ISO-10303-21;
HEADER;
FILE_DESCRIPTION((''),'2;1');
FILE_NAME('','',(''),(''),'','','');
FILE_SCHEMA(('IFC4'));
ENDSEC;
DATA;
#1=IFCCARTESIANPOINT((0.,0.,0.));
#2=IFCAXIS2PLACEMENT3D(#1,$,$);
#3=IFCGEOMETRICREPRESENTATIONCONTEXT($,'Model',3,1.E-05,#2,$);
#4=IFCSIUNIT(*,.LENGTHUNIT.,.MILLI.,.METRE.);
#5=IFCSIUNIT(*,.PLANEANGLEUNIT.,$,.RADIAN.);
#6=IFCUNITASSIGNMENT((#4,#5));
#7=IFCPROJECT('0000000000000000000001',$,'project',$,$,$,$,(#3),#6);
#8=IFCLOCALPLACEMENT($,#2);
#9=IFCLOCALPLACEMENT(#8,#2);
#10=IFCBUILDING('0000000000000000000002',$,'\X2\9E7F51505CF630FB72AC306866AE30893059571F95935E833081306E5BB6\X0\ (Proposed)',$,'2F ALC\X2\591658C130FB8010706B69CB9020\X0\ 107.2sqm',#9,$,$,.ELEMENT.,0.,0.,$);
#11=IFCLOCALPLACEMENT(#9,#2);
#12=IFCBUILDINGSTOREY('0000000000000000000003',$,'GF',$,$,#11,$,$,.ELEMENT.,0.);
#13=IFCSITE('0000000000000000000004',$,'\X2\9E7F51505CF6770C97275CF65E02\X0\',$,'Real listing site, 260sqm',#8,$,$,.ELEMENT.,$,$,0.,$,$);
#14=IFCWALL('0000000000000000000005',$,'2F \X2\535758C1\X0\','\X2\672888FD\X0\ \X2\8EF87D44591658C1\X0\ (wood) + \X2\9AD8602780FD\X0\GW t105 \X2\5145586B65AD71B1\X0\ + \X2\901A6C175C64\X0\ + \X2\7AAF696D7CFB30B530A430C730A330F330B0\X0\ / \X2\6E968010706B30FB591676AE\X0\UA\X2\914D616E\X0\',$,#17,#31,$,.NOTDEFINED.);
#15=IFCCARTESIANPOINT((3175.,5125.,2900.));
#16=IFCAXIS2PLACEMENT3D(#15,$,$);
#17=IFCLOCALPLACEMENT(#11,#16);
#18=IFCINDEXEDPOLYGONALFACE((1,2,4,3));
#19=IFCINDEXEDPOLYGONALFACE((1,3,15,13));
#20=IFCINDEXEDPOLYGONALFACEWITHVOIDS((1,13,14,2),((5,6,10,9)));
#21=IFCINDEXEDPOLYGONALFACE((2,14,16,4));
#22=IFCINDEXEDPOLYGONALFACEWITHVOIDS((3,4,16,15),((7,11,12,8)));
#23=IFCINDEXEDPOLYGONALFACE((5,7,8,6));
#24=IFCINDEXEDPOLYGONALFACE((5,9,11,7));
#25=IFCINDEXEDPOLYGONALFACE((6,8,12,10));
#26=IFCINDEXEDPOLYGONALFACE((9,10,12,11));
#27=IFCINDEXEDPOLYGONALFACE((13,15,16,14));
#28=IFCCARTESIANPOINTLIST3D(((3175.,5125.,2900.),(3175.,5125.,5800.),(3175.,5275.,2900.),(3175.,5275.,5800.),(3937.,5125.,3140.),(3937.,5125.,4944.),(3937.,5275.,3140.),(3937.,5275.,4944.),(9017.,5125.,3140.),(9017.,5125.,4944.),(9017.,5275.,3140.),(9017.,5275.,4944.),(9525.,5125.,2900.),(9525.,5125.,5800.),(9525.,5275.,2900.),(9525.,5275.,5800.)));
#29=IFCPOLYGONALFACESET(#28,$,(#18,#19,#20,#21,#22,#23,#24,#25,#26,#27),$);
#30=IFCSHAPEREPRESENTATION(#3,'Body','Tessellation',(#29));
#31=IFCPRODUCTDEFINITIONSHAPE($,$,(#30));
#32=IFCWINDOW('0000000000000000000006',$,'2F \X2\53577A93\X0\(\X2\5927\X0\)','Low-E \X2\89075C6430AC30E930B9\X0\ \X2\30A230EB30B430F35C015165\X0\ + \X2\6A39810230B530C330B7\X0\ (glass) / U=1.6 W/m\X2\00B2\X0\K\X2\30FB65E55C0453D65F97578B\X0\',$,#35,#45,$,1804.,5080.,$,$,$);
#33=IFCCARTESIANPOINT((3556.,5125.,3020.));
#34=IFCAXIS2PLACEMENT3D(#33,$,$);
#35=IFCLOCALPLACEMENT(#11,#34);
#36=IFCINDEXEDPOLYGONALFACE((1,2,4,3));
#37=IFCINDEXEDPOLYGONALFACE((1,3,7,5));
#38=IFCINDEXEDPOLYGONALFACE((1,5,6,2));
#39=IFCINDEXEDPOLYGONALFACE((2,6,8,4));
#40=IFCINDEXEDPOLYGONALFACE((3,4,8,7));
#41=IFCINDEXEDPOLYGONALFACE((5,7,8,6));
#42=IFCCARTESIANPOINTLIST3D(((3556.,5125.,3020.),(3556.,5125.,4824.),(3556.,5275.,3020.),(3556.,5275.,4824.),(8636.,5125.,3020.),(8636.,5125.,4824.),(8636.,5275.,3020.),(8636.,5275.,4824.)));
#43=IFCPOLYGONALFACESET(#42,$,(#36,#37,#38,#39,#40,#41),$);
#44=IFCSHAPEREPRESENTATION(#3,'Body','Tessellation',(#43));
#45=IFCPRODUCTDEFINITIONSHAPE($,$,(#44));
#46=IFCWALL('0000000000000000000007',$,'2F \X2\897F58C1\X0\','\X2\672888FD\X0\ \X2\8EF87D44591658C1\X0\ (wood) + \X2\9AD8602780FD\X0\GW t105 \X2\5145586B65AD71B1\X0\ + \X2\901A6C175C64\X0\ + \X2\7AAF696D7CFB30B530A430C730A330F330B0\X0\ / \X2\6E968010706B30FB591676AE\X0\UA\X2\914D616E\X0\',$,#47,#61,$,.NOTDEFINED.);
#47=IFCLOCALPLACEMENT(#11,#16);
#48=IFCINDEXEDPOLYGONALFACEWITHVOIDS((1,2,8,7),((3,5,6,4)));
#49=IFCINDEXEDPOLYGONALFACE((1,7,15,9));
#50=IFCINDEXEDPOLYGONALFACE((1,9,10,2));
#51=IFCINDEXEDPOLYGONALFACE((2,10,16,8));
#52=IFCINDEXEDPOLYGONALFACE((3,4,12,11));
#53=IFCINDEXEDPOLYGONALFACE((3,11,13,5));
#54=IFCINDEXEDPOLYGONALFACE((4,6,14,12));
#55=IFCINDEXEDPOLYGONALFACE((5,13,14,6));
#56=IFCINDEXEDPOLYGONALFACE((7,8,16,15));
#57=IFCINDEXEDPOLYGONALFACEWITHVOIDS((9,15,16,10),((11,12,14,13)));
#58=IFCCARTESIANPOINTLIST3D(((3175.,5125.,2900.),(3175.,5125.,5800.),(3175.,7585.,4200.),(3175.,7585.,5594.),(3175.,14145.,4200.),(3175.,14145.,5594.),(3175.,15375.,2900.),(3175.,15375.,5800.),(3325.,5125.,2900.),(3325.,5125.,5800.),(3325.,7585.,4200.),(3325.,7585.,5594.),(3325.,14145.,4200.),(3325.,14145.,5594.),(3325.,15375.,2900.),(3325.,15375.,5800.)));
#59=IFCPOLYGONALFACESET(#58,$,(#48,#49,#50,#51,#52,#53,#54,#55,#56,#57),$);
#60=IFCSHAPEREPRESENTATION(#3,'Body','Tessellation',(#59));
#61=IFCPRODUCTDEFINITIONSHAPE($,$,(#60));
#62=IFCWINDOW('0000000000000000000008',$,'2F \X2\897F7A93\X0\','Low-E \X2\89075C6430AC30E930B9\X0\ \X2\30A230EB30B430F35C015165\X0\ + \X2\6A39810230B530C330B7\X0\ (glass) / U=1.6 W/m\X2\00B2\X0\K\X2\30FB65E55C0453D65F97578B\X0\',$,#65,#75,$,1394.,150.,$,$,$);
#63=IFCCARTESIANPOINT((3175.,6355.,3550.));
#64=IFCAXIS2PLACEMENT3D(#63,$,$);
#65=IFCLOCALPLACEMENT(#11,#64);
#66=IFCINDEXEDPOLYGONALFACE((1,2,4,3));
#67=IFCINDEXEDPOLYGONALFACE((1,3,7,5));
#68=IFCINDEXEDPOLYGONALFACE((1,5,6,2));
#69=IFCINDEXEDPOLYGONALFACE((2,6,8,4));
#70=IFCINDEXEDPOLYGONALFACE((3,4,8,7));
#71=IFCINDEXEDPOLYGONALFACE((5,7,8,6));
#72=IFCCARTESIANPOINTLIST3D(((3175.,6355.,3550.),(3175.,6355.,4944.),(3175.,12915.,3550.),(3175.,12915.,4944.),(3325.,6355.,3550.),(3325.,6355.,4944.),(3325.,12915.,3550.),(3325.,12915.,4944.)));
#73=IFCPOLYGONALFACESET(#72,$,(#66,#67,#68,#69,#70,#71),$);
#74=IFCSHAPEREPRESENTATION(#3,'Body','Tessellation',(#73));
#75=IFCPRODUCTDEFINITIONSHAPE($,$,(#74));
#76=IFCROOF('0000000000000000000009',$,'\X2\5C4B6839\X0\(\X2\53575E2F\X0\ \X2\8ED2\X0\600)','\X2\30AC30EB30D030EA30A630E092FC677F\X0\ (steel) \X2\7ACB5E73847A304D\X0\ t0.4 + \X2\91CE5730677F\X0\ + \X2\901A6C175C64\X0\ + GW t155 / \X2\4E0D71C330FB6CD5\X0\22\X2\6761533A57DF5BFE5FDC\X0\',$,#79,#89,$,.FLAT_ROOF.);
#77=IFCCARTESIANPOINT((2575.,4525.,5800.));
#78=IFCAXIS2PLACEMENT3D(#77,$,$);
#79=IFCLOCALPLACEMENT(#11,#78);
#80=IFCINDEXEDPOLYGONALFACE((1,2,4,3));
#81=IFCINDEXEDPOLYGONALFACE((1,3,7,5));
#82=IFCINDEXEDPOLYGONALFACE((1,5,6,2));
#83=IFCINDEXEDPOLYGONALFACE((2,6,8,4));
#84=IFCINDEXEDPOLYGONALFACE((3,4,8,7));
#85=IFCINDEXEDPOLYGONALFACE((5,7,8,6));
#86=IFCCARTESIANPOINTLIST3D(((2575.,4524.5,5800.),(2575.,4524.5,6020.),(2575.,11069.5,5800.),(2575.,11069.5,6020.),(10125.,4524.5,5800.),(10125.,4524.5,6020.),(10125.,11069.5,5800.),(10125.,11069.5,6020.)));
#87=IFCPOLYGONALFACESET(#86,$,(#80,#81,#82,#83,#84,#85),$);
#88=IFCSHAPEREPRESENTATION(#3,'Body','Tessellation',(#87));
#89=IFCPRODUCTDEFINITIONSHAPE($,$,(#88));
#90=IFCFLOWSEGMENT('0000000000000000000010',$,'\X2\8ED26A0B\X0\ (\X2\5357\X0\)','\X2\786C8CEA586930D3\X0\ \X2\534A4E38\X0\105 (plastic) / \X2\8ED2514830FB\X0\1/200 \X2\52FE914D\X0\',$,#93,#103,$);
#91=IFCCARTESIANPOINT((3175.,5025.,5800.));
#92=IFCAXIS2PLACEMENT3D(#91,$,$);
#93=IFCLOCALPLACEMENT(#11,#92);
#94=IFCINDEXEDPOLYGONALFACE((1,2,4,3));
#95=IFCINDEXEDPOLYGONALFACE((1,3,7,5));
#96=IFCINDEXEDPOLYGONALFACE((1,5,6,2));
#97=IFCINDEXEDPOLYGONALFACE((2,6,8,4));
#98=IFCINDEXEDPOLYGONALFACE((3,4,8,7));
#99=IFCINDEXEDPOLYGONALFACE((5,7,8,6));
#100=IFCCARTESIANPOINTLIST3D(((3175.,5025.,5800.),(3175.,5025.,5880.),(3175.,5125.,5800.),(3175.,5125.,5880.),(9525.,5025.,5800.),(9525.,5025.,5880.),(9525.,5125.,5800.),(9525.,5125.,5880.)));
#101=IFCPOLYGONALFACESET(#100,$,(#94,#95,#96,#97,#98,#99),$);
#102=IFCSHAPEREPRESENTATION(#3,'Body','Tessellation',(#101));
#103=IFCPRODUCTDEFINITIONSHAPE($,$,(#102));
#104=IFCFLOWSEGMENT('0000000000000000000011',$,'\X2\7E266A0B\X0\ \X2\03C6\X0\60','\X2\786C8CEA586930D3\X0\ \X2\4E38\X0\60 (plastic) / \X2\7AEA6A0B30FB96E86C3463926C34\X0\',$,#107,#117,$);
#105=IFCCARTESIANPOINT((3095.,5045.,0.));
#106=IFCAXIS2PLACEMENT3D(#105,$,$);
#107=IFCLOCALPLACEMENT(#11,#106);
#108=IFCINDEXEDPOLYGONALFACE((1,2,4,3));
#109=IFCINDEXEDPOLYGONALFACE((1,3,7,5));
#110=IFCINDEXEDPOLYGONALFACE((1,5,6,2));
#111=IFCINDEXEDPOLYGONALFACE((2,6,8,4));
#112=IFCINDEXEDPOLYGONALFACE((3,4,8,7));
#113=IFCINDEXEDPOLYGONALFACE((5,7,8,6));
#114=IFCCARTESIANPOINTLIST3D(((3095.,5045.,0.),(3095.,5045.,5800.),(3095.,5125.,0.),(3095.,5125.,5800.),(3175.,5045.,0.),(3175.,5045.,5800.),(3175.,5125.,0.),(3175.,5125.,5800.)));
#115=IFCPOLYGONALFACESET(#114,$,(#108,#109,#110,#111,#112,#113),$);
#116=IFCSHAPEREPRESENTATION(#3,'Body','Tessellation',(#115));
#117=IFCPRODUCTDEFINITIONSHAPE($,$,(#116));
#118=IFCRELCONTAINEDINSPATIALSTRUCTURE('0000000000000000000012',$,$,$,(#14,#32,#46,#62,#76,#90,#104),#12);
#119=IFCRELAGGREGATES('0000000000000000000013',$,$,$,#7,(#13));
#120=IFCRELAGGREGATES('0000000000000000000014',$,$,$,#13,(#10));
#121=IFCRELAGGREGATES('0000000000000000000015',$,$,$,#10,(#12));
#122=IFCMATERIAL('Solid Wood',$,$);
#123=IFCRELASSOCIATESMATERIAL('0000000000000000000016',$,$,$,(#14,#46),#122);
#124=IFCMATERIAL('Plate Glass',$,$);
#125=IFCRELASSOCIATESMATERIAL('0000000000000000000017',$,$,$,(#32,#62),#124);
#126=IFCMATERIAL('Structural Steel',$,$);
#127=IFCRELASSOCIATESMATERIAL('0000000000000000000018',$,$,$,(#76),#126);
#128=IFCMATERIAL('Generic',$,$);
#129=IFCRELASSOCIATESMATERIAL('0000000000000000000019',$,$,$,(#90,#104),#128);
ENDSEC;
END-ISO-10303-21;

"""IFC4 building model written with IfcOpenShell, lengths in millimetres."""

from ifc_helpers import new_model, si_unit, frame, frame_2d, origin, place, context, project, spatial, rectangle, extrude, material, element, fill, save


model = new_model("IFC4")

# Units and contexts
model_context = context("Model", 3, precision=1e-05, world=origin())
ifc_project = project(units=[si_unit("LENGTHUNIT", "METRE", prefix="MILLI"), si_unit("PLANEANGLEUNIT", "RADIAN")], contexts=[model_context])

# Site, building, storey
site_placement = place(None, origin())
site = spatial("IfcSite", under=ifc_project, at=site_placement, Name="鹿児島県霧島市", ObjectType="Real listing site, 260sqm", CompositionType="ELEMENT", RefElevation=0.0)
building_placement = place(site_placement, origin())
building = spatial("IfcBuilding", under=site, at=building_placement, Name="鹿児島・犬と暮らす土間広めの家 (Proposed)", ObjectType="2F ALC外壁・耐火構造 107.2sqm", CompositionType="ELEMENT", ElevationOfRefHeight=0.0, ElevationOfTerrain=0.0)
storey_placement = place(building_placement, origin())
storey = spatial("IfcBuildingStorey", under=building, at=storey_placement, Name="GF", CompositionType="ELEMENT", Elevation=0.0)

# Shared definitions
ifc_material_1 = material(Name="Solid Wood")

# Shared definitions
ifc_material_2 = material(Name="Plate Glass")

# Walls, openings, windows
wall_1_placement = place(storey_placement, frame((3175.0, 5125.0, 2900.0)))
wall_1 = element("IfcWall", 1, at=wall_1_placement, inside=storey, material=ifc_material_1, Name="2F 南壁", Description="木製 軸組外壁 (wood) + 高性能GW t105 充填断熱 + 通気層 + 窯業系サイディング / 準耐火・外皮UA配慮", PredefinedType="NOTDEFINED", context=model_context, shape_type="SweptSolid", body=[
    extrude(rectangle(XDim=6350.0, YDim=150.0, at=frame_2d((3175.0, 75.0))), frame((3175.0, 5125.0, 2900.0)), (0.0, 0.0, 1.0), 2900.0),
])
opening_1_placement = place(storey_placement, frame((3556.0, 5125.0, 3020.0)))
opening_1 = element("IfcOpeningElement", 2, at=opening_1_placement, cuts=wall_1, PredefinedType="NOTDEFINED", context=model_context, shape_type="SweptSolid", body=[
    extrude(rectangle(XDim=5080.0, YDim=150.0, at=frame_2d((2540.0, 75.0))), frame((3556.0, 5125.0, 3020.0)), (0.0, 0.0, 1.0), 1804.0),
])
window_1_placement = place(storey_placement, frame((3556.0, 5125.0, 3020.0)))
window_1 = element("IfcWindow", 3, at=window_1_placement, inside=storey, material=ifc_material_2, Name="2F 南窓(大)", Description="Low-E 複層ガラス アルゴン封入 + 樹脂サッシ (glass) / U=1.6 W/m²K・日射取得型", OverallHeight=1804.0, OverallWidth=5080.0, context=model_context, shape_type="SweptSolid", body=[
    extrude(rectangle(XDim=5080.0, YDim=150.0, at=frame_2d((2540.0, 75.0))), frame((3556.0, 5125.0, 3020.0)), (0.0, 0.0, 1.0), 1804.0),
])
fill(opening_1, window_1)
wall_2_placement = place(storey_placement, frame((3175.0, 5125.0, 2900.0)))
wall_2 = element("IfcWall", 4, at=wall_2_placement, inside=storey, material=ifc_material_1, Name="2F 西壁", Description="木製 軸組外壁 (wood) + 高性能GW t105 充填断熱 + 通気層 + 窯業系サイディング / 準耐火・外皮UA配慮", PredefinedType="NOTDEFINED", context=model_context, shape_type="SweptSolid", body=[
    extrude(rectangle(XDim=150.0, YDim=10250.0, at=frame_2d((75.0, 5125.0))), frame((3175.0, 5125.0, 2900.0)), (0.0, 0.0, 1.0), 2900.0),
])
opening_2_placement = place(storey_placement, frame((3175.0, 6355.0, 3550.0)))
opening_2 = element("IfcOpeningElement", 5, at=opening_2_placement, cuts=wall_2, PredefinedType="NOTDEFINED", context=model_context, shape_type="SweptSolid", body=[
    extrude(rectangle(XDim=150.0, YDim=6560.0, at=frame_2d((75.0, 3280.0))), frame((3175.0, 6355.0, 3550.0)), (0.0, 0.0, 1.0), 1394.0),
])
window_2_placement = place(storey_placement, frame((3175.0, 6355.0, 3550.0)))
window_2 = element("IfcWindow", 6, at=window_2_placement, inside=storey, material=ifc_material_2, Name="2F 西窓", Description="Low-E 複層ガラス アルゴン封入 + 樹脂サッシ (glass) / U=1.6 W/m²K・日射取得型", OverallHeight=1394.0, OverallWidth=150.0, context=model_context, shape_type="SweptSolid", body=[
    extrude(rectangle(XDim=150.0, YDim=6560.0, at=frame_2d((75.0, 3280.0))), frame((3175.0, 6355.0, 3550.0)), (0.0, 0.0, 1.0), 1394.0),
])
fill(opening_2, window_2)

# Roof
ifc_material_3 = material(Name="Structural Steel")
for number, where, name in (
    (7, (2575.0, 4525.0, 5800.0), "屋根(南帯 軒600)"),
):
    element("IfcRoof", number, at=place(storey_placement, frame(where)), inside=storey, material=ifc_material_3, Name=name, Description="ガルバリウム鋼板 (steel) 立平葺き t0.4 + 野地板 + 通気層 + GW t155 / 不燃・法22条区域対応", PredefinedType="FLAT_ROOF", context=model_context, shape_type="SweptSolid", body=[
        extrude(rectangle(XDim=7550.0, YDim=6545.0, at=frame_2d((3775.0, 3272.0))), frame((2575.0, 4525.0, 5800.0)), (0.0, 0.0, 1.0), 220.0),
    ])

# Flow segments
ifc_material_4 = material(Name="Generic")
flow_segment_1_placement = place(storey_placement, frame((3175.0, 5025.0, 5800.0)))
element("IfcFlowSegment", 8, at=flow_segment_1_placement, inside=storey, material=ifc_material_4, Name="軒樋 (南)", Description="硬質塩ビ 半丸105 (plastic) / 軒先・1/200 勾配", context=model_context, shape_type="SweptSolid", body=[
    extrude(rectangle(XDim=6350.0, YDim=100.0, at=frame_2d((3175.0, 50.0))), frame((3175.0, 5025.0, 5800.0)), (0.0, 0.0, 1.0), 80.0),
])
flow_segment_2_placement = place(storey_placement, frame((3095.0, 5045.0, 0.0)))
element("IfcFlowSegment", 9, at=flow_segment_2_placement, inside=storey, material=ifc_material_4, Name="縦樋 φ60", Description="硬質塩ビ 丸60 (plastic) / 竪樋・雨水排水", context=model_context, shape_type="SweptSolid", body=[
    extrude(rectangle(XDim=80.0, YDim=80.0, at=frame_2d((40.0, 40.0))), frame((3095.0, 5045.0, 0.0)), (0.0, 0.0, 1.0), 5800.0),
])

save(model, "model.ifc")
